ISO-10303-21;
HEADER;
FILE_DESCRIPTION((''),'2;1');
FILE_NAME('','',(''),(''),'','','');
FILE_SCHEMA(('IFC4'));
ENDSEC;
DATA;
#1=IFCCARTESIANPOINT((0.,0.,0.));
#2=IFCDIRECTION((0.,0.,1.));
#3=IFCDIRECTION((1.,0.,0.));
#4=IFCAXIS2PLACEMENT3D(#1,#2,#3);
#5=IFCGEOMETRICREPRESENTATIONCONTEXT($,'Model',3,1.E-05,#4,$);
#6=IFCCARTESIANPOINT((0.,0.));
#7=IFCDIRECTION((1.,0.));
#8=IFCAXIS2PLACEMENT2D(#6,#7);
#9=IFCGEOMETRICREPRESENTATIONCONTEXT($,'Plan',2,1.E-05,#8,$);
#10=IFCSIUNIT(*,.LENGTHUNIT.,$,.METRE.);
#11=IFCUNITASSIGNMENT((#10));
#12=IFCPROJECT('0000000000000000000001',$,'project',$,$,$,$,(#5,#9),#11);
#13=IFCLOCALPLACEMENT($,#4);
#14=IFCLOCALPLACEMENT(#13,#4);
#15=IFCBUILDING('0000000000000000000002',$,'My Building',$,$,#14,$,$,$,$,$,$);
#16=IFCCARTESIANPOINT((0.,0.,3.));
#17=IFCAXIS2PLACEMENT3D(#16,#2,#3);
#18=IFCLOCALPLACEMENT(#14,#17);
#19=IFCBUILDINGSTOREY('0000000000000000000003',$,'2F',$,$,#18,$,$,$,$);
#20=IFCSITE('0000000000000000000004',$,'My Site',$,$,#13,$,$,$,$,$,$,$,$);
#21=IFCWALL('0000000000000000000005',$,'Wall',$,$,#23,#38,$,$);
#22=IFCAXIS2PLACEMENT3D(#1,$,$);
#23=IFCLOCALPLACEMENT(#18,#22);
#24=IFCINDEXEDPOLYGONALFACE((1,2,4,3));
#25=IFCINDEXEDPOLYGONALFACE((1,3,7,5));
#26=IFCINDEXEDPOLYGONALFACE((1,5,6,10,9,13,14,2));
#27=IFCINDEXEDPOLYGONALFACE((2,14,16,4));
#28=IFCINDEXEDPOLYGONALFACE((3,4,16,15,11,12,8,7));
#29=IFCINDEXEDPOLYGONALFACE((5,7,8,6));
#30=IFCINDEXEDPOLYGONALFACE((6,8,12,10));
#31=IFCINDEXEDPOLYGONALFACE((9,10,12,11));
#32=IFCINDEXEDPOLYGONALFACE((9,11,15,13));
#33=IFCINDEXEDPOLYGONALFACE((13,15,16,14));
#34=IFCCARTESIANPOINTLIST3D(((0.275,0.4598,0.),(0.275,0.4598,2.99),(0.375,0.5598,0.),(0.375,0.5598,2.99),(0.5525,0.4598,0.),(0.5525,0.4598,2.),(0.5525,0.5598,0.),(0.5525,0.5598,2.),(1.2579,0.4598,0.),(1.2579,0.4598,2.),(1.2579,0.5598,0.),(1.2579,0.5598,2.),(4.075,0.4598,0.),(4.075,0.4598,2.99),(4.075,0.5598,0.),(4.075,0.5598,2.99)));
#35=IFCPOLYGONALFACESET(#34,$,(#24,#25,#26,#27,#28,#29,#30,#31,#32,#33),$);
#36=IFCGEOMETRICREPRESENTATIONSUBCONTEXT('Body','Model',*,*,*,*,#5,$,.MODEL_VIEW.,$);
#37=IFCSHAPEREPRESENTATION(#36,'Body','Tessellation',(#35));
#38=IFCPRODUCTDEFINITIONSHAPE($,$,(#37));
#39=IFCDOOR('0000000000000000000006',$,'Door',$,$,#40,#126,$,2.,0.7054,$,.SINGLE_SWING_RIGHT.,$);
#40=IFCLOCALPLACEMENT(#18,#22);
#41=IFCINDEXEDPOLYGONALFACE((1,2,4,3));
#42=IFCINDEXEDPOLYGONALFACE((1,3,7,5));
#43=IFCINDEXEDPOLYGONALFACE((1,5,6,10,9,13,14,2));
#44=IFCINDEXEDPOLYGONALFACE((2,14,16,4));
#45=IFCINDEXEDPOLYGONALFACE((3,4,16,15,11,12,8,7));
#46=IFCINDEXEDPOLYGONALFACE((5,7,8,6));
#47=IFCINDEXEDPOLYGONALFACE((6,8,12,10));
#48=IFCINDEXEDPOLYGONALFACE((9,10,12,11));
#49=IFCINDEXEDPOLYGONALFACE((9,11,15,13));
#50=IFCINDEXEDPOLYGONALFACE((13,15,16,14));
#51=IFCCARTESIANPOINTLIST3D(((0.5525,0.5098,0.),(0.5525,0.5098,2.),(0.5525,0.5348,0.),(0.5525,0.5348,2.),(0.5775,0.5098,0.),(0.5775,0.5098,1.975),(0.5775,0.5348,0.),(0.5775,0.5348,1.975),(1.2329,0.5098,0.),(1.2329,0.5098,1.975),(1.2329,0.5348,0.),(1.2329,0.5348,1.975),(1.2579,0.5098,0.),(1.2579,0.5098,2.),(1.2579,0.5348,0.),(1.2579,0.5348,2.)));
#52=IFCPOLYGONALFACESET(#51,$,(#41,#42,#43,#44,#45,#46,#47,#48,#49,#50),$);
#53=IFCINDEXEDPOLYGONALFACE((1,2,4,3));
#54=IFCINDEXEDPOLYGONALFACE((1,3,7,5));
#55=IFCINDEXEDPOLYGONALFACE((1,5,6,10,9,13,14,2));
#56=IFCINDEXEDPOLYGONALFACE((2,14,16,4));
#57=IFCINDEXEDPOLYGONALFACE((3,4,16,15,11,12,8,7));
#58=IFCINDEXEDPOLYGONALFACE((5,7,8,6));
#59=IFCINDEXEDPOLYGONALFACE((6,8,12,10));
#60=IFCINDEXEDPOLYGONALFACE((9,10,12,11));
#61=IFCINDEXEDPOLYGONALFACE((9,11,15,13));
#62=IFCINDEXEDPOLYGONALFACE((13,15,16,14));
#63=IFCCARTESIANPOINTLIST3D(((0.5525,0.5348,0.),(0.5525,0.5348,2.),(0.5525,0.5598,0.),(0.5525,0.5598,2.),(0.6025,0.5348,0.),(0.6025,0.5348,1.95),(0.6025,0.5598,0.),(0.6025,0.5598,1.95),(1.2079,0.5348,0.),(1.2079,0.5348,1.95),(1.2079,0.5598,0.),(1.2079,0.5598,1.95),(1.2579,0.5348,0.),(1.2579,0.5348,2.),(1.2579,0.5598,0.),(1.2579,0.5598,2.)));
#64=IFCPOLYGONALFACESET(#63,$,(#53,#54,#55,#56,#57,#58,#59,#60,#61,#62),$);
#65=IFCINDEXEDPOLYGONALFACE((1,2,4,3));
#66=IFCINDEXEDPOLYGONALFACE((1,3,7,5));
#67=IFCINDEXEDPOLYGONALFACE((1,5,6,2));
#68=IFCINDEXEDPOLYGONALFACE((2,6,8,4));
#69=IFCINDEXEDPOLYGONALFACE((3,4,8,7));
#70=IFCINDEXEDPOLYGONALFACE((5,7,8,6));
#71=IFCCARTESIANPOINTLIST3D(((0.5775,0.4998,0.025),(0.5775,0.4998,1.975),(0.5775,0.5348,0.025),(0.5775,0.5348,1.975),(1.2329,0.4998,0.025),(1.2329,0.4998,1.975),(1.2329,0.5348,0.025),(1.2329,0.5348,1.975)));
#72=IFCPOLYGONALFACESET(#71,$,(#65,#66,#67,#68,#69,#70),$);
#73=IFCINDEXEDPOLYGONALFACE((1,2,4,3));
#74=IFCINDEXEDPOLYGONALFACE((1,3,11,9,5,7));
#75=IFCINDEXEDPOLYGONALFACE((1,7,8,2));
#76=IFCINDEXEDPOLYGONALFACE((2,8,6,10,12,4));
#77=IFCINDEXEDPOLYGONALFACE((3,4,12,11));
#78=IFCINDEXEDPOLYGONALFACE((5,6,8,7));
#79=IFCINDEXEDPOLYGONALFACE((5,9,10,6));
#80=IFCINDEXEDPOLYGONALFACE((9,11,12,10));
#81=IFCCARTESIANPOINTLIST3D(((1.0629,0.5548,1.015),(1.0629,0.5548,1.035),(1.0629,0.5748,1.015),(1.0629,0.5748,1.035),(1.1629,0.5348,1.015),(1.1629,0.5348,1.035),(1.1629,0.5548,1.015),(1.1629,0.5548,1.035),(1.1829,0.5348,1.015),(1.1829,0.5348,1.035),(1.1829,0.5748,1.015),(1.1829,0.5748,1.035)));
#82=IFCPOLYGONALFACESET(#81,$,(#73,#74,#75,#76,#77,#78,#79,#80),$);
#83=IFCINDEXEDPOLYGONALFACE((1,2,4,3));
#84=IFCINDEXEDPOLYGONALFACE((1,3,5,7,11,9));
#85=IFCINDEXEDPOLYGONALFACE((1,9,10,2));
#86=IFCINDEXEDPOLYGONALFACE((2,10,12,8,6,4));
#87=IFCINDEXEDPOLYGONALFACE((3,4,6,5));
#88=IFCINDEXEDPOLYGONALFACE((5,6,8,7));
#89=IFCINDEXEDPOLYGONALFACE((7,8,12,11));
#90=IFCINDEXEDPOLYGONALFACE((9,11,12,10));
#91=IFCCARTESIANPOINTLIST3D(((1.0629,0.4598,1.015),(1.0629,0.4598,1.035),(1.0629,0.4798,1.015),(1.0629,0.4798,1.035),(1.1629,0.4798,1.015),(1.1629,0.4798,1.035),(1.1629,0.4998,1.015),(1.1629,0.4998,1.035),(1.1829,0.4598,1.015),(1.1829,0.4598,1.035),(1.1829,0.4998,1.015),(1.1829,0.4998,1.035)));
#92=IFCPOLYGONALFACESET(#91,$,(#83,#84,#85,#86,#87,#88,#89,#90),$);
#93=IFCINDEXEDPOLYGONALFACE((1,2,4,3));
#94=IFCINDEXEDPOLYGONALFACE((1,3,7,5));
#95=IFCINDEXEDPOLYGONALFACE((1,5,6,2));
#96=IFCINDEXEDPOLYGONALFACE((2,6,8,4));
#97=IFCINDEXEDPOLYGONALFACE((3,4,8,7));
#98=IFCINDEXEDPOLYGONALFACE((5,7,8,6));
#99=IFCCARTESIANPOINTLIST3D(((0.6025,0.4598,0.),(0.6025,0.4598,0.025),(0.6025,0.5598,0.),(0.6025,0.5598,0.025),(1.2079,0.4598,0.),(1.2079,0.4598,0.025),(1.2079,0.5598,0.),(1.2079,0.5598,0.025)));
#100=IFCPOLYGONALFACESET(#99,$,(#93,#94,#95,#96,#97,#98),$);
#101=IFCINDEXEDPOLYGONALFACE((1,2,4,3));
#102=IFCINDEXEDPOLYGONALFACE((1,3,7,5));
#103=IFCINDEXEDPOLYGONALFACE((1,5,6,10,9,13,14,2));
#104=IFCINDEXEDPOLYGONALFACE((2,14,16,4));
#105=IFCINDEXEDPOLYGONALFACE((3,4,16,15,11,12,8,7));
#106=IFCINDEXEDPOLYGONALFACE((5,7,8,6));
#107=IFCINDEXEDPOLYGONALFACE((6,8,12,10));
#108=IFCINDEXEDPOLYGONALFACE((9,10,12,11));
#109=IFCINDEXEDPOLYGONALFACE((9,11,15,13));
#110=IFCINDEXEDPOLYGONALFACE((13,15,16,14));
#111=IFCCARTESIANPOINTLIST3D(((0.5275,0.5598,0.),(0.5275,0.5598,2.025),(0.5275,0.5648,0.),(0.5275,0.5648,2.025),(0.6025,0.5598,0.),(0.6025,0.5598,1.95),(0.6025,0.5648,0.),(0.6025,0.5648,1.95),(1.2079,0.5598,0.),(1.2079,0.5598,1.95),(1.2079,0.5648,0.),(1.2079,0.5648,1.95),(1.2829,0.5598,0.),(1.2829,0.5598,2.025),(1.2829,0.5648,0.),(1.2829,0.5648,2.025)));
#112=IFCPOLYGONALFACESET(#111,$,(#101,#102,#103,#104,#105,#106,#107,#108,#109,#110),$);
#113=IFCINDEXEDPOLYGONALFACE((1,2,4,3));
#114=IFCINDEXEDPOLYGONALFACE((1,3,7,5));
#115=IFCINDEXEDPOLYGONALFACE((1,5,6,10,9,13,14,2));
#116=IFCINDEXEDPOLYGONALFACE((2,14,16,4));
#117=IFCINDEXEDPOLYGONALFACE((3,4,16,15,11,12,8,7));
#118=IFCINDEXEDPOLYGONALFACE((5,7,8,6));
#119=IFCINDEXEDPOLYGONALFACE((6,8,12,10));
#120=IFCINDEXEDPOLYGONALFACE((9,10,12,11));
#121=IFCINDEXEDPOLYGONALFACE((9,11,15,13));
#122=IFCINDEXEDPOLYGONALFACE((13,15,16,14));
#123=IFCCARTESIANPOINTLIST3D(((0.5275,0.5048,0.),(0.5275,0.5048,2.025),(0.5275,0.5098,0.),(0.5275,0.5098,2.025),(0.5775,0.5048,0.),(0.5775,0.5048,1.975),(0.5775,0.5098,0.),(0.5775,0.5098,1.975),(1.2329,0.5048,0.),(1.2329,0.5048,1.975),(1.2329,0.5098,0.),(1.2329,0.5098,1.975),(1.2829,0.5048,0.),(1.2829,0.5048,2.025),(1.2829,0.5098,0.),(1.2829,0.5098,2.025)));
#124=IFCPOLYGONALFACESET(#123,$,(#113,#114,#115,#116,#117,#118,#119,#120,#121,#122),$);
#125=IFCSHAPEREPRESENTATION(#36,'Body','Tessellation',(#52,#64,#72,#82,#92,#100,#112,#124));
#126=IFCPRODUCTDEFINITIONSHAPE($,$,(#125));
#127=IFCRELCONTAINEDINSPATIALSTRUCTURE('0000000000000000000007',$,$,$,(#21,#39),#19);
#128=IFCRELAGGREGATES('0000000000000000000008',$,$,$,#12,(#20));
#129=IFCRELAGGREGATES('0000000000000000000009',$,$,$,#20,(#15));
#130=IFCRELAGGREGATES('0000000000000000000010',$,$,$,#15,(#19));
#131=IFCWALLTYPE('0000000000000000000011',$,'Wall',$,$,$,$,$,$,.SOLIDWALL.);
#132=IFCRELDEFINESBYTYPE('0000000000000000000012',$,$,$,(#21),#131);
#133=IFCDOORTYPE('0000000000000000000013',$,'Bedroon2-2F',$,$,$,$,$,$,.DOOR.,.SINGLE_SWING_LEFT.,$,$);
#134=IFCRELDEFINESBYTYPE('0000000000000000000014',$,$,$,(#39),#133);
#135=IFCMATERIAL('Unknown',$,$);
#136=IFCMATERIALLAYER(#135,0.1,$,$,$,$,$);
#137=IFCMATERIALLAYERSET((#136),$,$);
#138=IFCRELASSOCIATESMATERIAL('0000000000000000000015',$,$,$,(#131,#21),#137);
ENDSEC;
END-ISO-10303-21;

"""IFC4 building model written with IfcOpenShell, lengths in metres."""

from ifc_helpers import new_model, entity, si_unit, frame, origin_with_axes, origin_2d_with_axis, place, context, subcontext, project, spatial, line, indexed_curve, outline, extrude, shape, source, transform, mapped, material, layer, layer_set, layer_usage, type_object, type_shapes, element, fill, save


model = new_model("IFC4")

# Units and contexts
model_context = context("Model", 3, precision=1e-05, world=origin_with_axes())
plan_context = context("Plan", 2, precision=1e-05, world=origin_2d_with_axis())
body_context_1 = subcontext(model_context, "Body", "Model", "MODEL_VIEW")
body_context_2 = subcontext(plan_context, "Body", "Plan", "PLAN_VIEW")
ifc_project = project(units=[si_unit("LENGTHUNIT", "METRE")], contexts=[model_context, plan_context])

# Site, building, storey
site_placement = place(None, origin_with_axes())
site = spatial("IfcSite", under=ifc_project, at=site_placement, Name="My Site")
building_placement = place(site_placement, origin_with_axes())
building = spatial("IfcBuilding", under=site, at=building_placement, Name="My Building")
storey_placement = place(building_placement, frame((0.0, 0.0, 3.0), z_axis=(0.0, 0.0, 1.0), x_axis=(1.0, 0.0, 0.0)))
storey = spatial("IfcBuildingStorey", under=building, at=storey_placement, Name="2F")

# Shared definitions
ifc_material = material(Name="Unknown")

# Shared definitions
ifc_layer_1 = layer(ifc_material, 0.1)
ifc_layer_set_1 = layer_set([ifc_layer_1])
wall_type = type_object("IfcWallType", Name="Wall", PredefinedType="SOLIDWALL", material=ifc_layer_set_1)

# Wall, opening, door
ifc_layer_usage_1 = layer_usage(ifc_layer_set_1, "AXIS2", "POSITIVE", 0.0)
wall_1_placement = place(storey_placement, frame((0.275, 0.4598, 0.0), z_axis=(0.0, 0.0, 1.0), x_axis=(1.0, 0.0, 0.0)))
wall_1 = element("IfcWall", 1, at=wall_1_placement, inside=storey, type_object=wall_type, material=ifc_layer_usage_1, Name="Wall", context=body_context_1, shape_type="SweptSolid", body=[
    extrude(outline(indexed_curve([(0.0, 0.0), (0.1, 0.1), (3.8, 0.1), (3.8, 0.0)], segments=[line(1, 2, 3, 4, 1)])), origin_with_axes(), (0.0, 0.0, 1.0), 2.99),
])
shared_shape_1 = source(origin_with_axes(), body_context_1, "Body", "SweptSolid", [
    extrude(outline(indexed_curve([(0.0, 0.0), (0.7054, 0.0), (0.7054, 2.0), (0.0, 2.0)], segments=[line(1, 2, 3, 4, 1)])), frame((0.0, -0.6, 0.0), z_axis=(0.0, -1.0, 0.0), x_axis=(1.0, 0.0, 0.0)), (0.0, 0.0, -1.0), 1.2),
])
opening_1_placement = place(wall_1_placement, frame((0.9829, 0.1, 0.0), z_axis=(0.0, 0.0, 1.0), x_axis=(-1.0, 0.0, 0.0)))
opening_1 = element("IfcOpeningElement", 2, at=opening_1_placement, cuts=wall_1, PredefinedType="OPENING", context=body_context_1, shape_type="MappedRepresentation", body=[
    mapped(shared_shape_1, transform((0.0, 0.0, 0.0), x_axis=(1.0, 0.0, 0.0), y_axis=(0.0, 1.0, 0.0), z_axis=(0.0, 0.0, 1.0), scale=1.0)),
])
door_type_1 = type_object("IfcDoorType", Name="Bedroon2-2F", OperationType="SINGLE_SWING_LEFT", PredefinedType="DOOR")
shared_shape_2 = source(origin_with_axes(), body_context_1, "Body", "SweptSolid", [
    extrude(outline(indexed_curve([(0.0, 0.0), (0.0, 2.0), (0.7054, 2.0), (0.7054, 0.0), (0.6804, 0.0), (0.6804, 1.975), (0.025, 1.975), (0.025, 0.0)], segments=[line(1, 2, 3, 4, 5, 6, 7, 8, 1)])), frame((0.0, 0.025, 0.0), z_axis=(0.0, -1.0, 0.0), x_axis=(1.0, 0.0, 0.0)), (0.0, 0.0, -1.0), 0.025),
    extrude(outline(indexed_curve([(0.0, 0.0), (0.0, 2.0), (0.7054, 2.0), (0.7054, 0.0), (0.6554, 0.0), (0.6554, 1.95), (0.05, 1.95), (0.05, 0.0)], segments=[line(1, 2, 3, 4, 5, 6, 7, 8, 1)])), frame((0.0, 0.0, 0.0), z_axis=(0.0, -1.0, 0.0), x_axis=(1.0, 0.0, 0.0)), (0.0, 0.0, -1.0), 0.025),
    extrude(outline(indexed_curve([(0.0, 0.0), (0.6554, 0.0), (0.6554, 0.035), (0.0, 0.035)], segments=[line(1, 2, 3, 4, 1)])), frame((0.025, 0.025, 0.025), z_axis=(0.0, 0.0, 1.0), x_axis=(1.0, 0.0, 0.0)), (0.0, 0.0, 1.0), 1.95),
    extrude(outline(indexed_curve([(0.0, 0.0), (0.0, -0.04), (0.12, -0.04), (0.12, -0.02), (0.02, -0.02), (0.02, 0.0)], segments=[line(1, 2, 3, 4, 5, 6, 1)])), frame((0.075, 0.025, 1.015), z_axis=(0.0, 0.0, 1.0), x_axis=(1.0, 0.0, 0.0)), (0.0, 0.0, 1.0), 0.02),
    extrude(outline(indexed_curve([(0.0, 0.0), (0.0, 0.04), (0.12, 0.04), (0.12, 0.02), (0.02, 0.02), (0.02, 0.0)], segments=[line(1, 2, 3, 4, 5, 6, 1)])), frame((0.075, 0.06, 1.015), z_axis=(0.0, 0.0, 1.0), x_axis=(1.0, 0.0, 0.0)), (0.0, 0.0, 1.0), 0.02),
    extrude(outline(indexed_curve([(0.0, 0.0), (0.6054, 0.0), (0.6054, 0.1), (0.0, 0.1)], segments=[line(1, 2, 3, 4, 1)])), frame((0.05, 0.0, 0.0), z_axis=(0.0, 0.0, 1.0), x_axis=(1.0, 0.0, 0.0)), (0.0, 0.0, 1.0), 0.025),
    extrude(outline(indexed_curve([(0.0, 0.0), (0.0, 2.025), (0.7554, 2.025), (0.7554, 0.0), (0.6804, 0.0), (0.6804, 1.95), (0.075, 1.95), (0.075, 0.0)], segments=[line(1, 2, 3, 4, 5, 6, 7, 8, 1)])), frame((-0.025, -0.005, 0.0), z_axis=(0.0, -1.0, 0.0), x_axis=(1.0, 0.0, 0.0)), (0.0, 0.0, -1.0), 0.005),
    extrude(outline(indexed_curve([(0.0, 0.0), (0.0, 2.025), (0.7554, 2.025), (0.7554, 0.0), (0.7054, 0.0), (0.7054, 1.975), (0.05, 1.975), (0.05, 0.0)], segments=[line(1, 2, 3, 4, 5, 6, 7, 8, 1)])), frame((-0.025, 0.05, 0.0), z_axis=(0.0, -1.0, 0.0), x_axis=(1.0, 0.0, 0.0)), (0.0, 0.0, -1.0), 0.005),
])
shared_shape_3 = source(origin_with_axes(), body_context_2, "Body", "Curve2D", [
    entity("IfcIndexedPolyCurve", entity("IfcCartesianPointList2D", [[0.0, 0.0], [0.0, 0.05], [0.025, 0.05], [0.025, 0.025], [0.05, 0.025], [0.05, 0.0]]), [entity("IfcLineIndex", [1, 2, 3, 4, 5, 6, 1])]),
    entity("IfcIndexedPolyCurve", entity("IfcCartesianPointList2D", [[0.7054, 0.0], [0.7054, 0.05], [0.6804, 0.05], [0.6804, 0.025], [0.6554, 0.025], [0.6554, 0.0]]), [entity("IfcLineIndex", [1, 2, 3, 4, 5, 6, 1])]),
    entity("IfcTrimmedCurve", entity("IfcEllipse", entity("IfcAxis2Placement2D", entity("IfcCartesianPoint", [0.6454, 0.05]), entity("IfcDirection", [1.0, 0.0])), 0.6204, 0.6554), [entity("IfcCartesianPoint", [0.6454, 0.7054])], [entity("IfcCartesianPoint", [0.025, 0.05])], True, "CARTESIAN"),
    entity("IfcIndexedPolyCurve", entity("IfcCartesianPointList2D", [[0.6804, 0.05], [0.6454, 0.05], [0.6454, 0.7054], [0.6804, 0.7054]]), [entity("IfcLineIndex", [1, 2, 3, 4, 1])]),
])
type_shapes(door_type_1, [shared_shape_2, shared_shape_3])
door_1_placement = place(opening_1_placement, origin_with_axes())
door_1 = element("IfcDoor", 3, at=door_1_placement, inside=storey, type_object=door_type_1, Name="Door", OperationType="SINGLE_SWING_RIGHT", OverallHeight=2.0, OverallWidth=0.7054, shapes=[
    shape(body_context_1, "Body", "MappedRepresentation", [mapped(shared_shape_2, transform((0.0, 0.0, 0.0), x_axis=(1.0, 0.0, 0.0), y_axis=(0.0, 1.0, 0.0), z_axis=(0.0, 0.0, 1.0), scale=1.0))]),
    shape(body_context_2, "Body", "MappedRepresentation", [mapped(shared_shape_3, transform((0.0, 0.0, 0.0), x_axis=(1.0, 0.0, 0.0), y_axis=(0.0, 1.0, 0.0), z_axis=(0.0, 0.0, 1.0), scale=1.0))]),
])
fill(opening_1, door_1)

save(model, "model.ifc")
